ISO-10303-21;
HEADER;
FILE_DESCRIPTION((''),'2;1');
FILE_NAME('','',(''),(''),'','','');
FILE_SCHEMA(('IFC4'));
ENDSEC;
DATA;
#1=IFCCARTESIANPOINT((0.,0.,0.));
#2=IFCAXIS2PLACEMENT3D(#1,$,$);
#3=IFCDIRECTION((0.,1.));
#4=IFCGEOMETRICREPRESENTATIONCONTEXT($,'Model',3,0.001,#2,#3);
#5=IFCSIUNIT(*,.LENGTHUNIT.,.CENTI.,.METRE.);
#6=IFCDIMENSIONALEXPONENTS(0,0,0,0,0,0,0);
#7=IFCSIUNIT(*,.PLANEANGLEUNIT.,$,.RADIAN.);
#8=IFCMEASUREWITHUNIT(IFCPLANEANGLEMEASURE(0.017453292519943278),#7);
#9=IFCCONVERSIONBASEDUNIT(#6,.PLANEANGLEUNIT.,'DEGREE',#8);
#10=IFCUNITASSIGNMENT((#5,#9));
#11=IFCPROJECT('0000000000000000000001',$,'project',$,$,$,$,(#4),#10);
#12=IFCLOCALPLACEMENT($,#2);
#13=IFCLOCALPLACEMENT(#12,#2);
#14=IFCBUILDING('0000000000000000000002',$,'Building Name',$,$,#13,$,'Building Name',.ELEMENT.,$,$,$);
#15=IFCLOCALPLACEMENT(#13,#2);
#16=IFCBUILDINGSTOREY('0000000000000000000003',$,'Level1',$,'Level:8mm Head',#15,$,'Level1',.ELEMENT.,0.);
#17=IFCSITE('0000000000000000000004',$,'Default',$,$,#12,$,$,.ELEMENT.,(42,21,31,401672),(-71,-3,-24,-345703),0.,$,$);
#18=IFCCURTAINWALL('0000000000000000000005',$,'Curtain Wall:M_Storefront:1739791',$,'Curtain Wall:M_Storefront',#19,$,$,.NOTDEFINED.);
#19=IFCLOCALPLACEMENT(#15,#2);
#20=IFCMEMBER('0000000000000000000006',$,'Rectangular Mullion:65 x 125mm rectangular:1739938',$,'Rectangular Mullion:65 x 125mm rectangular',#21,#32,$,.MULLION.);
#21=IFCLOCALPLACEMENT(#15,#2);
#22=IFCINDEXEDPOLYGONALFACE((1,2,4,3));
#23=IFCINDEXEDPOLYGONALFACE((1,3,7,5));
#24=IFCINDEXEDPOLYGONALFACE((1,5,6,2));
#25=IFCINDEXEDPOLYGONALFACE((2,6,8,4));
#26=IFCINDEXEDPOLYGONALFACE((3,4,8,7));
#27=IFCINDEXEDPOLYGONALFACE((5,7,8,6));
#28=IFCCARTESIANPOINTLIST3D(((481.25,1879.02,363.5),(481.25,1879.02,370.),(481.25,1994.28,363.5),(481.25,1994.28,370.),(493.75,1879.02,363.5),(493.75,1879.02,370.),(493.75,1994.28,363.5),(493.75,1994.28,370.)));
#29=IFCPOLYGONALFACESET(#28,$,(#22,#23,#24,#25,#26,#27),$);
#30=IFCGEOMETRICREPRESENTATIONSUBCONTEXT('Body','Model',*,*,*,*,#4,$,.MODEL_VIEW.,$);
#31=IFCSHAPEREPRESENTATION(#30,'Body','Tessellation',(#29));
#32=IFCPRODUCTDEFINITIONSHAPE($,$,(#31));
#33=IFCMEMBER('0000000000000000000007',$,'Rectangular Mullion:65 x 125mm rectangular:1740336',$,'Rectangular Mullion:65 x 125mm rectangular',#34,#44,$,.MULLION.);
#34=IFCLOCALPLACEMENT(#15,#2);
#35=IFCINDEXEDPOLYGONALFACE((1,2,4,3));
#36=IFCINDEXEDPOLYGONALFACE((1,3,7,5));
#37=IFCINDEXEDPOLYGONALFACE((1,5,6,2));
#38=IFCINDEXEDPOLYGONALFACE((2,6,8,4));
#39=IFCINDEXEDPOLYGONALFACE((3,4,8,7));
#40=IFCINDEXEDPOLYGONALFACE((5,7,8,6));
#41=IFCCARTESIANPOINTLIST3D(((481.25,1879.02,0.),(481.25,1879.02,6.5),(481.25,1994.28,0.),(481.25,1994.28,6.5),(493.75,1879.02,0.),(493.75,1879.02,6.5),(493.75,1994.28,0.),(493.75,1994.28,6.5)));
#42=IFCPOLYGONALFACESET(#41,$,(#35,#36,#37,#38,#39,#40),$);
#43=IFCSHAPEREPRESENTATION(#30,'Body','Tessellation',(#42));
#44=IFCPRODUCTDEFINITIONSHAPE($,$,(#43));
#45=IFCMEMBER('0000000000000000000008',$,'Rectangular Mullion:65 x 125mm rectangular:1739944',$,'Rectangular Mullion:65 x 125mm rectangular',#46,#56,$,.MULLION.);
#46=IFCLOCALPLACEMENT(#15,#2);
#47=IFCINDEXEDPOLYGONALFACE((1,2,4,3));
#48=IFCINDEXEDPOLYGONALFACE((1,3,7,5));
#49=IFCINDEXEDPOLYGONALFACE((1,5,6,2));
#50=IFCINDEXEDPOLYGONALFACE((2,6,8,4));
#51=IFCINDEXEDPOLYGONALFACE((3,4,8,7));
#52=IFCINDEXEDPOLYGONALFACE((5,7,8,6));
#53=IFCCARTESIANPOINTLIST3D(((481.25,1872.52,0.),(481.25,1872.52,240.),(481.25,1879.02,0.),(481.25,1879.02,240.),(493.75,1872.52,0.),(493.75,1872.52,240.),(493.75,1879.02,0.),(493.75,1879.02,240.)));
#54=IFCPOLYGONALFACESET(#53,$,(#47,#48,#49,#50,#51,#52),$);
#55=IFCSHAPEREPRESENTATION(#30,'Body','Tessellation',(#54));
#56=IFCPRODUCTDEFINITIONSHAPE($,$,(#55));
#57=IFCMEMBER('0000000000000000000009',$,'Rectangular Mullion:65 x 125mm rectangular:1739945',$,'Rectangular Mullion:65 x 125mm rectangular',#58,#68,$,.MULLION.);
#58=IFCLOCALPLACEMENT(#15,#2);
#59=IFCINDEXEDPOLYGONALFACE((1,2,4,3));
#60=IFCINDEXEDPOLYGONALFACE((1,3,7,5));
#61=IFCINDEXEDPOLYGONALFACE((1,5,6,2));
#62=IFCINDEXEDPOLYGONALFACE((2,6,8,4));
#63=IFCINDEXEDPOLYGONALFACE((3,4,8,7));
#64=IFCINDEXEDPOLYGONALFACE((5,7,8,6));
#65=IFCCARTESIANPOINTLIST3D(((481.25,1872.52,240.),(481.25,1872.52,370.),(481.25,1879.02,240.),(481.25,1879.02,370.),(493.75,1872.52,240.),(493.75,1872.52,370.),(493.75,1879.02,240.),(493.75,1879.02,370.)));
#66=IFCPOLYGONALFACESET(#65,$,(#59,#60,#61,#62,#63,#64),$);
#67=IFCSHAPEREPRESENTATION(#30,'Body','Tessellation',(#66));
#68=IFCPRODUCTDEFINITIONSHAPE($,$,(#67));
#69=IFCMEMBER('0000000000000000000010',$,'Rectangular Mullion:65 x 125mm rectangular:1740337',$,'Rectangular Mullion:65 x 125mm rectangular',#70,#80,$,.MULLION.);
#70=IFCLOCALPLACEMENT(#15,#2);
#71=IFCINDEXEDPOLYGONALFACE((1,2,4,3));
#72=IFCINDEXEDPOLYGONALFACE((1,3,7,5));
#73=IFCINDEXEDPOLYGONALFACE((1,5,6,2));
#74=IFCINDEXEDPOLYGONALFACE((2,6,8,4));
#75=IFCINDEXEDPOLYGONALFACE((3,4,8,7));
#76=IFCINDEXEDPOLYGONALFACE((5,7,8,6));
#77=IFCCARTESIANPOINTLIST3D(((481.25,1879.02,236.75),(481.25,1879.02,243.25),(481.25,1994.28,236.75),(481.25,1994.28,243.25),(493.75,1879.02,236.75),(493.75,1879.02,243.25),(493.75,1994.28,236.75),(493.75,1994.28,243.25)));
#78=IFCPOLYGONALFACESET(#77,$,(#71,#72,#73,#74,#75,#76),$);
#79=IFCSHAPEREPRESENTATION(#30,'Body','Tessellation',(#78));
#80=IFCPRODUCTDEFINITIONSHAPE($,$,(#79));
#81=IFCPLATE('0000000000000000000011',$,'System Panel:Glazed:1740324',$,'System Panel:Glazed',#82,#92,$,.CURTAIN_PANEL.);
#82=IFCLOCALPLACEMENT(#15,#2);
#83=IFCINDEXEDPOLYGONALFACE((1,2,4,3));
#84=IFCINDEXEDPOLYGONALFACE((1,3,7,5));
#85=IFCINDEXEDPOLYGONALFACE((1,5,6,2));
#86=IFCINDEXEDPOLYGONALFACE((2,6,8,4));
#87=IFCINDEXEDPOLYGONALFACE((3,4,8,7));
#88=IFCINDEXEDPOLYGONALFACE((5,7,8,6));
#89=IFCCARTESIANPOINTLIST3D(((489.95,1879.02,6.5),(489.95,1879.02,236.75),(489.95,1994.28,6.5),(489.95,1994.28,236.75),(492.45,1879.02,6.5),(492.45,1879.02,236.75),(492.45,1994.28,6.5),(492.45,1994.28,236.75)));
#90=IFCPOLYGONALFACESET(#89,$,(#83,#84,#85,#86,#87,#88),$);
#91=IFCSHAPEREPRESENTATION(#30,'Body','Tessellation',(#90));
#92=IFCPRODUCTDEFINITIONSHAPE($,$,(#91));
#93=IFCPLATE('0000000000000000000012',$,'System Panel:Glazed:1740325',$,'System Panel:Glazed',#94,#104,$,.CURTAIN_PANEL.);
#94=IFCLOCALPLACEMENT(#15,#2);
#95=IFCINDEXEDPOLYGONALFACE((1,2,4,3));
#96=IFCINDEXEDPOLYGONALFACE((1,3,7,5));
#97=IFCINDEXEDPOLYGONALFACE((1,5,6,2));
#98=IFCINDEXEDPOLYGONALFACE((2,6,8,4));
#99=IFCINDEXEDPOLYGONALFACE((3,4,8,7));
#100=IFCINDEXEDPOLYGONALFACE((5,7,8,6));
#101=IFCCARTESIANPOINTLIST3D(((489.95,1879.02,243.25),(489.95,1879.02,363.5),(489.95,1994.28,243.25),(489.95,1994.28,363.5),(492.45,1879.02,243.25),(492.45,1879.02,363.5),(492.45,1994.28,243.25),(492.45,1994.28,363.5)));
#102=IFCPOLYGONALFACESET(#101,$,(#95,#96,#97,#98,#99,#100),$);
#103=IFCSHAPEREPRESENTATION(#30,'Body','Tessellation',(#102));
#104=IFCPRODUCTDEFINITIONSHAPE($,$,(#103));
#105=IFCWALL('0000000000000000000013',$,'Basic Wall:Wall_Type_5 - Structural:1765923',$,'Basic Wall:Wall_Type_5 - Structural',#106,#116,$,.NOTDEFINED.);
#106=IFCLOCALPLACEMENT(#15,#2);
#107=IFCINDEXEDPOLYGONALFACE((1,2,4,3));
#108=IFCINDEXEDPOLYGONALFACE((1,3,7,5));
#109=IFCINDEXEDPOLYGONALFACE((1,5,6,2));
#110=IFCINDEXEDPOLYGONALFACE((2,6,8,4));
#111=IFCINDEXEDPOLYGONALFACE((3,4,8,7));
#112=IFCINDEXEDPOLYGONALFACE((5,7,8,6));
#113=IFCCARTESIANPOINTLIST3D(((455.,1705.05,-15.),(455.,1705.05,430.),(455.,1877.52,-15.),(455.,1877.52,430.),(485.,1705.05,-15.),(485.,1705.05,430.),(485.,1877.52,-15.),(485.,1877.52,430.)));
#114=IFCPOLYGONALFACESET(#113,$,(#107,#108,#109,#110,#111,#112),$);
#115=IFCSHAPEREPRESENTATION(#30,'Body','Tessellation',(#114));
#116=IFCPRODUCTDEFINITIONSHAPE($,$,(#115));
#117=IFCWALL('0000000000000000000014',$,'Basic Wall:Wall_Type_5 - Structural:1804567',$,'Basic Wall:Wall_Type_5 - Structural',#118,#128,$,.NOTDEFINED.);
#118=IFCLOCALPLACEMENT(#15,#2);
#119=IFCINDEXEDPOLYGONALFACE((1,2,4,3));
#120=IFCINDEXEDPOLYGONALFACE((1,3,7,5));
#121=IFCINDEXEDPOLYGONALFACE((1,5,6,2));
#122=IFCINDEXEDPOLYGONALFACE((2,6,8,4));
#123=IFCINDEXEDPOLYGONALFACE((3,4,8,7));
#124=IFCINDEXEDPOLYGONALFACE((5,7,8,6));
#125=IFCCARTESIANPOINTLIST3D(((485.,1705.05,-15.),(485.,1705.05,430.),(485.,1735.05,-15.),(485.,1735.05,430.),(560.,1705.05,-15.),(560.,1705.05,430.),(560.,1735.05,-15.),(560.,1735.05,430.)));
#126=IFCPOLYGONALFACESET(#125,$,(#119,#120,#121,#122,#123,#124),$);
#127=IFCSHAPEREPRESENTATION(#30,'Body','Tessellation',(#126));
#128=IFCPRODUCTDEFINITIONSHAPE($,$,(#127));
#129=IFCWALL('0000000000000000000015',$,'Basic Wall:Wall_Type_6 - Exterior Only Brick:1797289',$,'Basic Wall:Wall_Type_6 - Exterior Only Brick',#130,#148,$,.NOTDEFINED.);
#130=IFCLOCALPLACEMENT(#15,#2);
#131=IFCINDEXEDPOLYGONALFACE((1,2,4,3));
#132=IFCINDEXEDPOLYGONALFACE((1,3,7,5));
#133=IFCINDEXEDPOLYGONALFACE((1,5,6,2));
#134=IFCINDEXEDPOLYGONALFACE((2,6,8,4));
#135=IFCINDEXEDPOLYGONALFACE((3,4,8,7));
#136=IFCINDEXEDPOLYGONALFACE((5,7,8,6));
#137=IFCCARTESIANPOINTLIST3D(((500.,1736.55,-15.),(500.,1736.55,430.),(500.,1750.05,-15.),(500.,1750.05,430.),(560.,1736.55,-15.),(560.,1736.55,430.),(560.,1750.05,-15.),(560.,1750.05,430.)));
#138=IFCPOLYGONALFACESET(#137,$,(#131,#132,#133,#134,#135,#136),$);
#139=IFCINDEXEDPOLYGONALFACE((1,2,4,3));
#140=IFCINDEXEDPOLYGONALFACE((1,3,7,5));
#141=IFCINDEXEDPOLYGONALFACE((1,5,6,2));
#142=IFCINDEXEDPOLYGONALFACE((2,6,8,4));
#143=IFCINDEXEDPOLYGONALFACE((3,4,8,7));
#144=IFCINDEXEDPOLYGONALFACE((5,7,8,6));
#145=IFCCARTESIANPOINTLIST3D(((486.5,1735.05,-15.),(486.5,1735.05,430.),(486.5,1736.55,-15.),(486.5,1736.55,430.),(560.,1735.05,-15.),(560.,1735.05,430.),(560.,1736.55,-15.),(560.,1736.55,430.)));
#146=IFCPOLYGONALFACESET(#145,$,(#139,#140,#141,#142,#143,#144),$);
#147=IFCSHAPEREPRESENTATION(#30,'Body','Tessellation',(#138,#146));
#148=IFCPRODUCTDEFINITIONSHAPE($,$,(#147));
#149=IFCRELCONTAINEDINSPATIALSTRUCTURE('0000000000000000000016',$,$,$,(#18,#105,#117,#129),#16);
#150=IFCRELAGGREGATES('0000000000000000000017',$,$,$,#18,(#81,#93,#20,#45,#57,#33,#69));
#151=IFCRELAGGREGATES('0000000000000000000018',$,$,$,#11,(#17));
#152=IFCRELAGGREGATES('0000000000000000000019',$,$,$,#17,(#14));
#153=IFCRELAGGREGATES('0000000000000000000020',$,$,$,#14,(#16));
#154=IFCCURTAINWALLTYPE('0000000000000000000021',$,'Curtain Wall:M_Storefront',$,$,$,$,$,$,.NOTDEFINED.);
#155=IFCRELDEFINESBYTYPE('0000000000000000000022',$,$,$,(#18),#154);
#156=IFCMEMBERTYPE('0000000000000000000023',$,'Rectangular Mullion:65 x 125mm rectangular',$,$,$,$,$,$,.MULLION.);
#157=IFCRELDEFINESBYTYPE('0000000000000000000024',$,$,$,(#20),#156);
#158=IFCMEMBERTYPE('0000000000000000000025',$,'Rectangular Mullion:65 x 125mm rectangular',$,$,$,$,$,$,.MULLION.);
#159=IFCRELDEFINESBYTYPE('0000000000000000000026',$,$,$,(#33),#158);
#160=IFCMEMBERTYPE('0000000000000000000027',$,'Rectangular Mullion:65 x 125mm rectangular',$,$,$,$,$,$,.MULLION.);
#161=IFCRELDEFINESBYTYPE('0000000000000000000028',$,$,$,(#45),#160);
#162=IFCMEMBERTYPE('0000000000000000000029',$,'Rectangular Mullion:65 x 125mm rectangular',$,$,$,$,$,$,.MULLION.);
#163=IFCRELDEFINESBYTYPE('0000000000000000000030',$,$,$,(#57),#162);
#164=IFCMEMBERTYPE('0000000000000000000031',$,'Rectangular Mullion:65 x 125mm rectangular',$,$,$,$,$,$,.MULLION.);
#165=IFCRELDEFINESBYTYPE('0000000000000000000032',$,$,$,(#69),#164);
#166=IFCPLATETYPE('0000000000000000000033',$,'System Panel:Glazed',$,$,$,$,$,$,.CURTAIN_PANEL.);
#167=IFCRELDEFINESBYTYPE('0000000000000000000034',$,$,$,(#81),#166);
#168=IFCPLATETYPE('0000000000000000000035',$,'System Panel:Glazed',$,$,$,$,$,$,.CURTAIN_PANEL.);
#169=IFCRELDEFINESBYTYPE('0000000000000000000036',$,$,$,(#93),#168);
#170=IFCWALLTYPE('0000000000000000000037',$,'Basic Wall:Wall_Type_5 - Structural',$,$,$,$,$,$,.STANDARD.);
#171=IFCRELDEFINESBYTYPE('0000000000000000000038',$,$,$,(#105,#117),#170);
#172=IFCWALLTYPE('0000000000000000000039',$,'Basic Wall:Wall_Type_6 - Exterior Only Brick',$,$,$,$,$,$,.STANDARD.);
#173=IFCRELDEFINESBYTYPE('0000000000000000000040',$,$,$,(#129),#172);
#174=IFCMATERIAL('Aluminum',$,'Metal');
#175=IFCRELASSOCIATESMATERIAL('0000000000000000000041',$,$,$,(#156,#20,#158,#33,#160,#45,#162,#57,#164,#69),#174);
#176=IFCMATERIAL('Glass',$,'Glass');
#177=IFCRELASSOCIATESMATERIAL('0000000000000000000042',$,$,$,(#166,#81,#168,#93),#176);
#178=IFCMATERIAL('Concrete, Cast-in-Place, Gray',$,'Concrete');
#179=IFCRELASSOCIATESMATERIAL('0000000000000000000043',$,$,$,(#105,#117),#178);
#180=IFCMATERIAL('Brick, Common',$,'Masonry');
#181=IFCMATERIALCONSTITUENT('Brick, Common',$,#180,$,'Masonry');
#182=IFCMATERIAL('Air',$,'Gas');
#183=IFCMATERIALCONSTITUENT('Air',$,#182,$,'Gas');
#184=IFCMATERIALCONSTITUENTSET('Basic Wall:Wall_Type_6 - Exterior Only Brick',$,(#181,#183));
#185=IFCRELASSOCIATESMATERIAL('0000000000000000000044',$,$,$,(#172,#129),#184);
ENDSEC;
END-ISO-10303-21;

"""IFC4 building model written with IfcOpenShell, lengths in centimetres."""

from ifc_helpers import new_model, entity, si_unit, converted_unit, direction, frame, origin, place, context, subcontext, project, spatial, indexed_curve, outline, extrude, source, transform, mapped, material, constituent, constituent_set, type_object, type_shapes, element, aggregate, save


model = new_model("IFC4")

# Units and contexts
model_context = context("Model", 3, precision=0.001, world=origin(), true_north=direction((0.0, 1.0)))
body_context = subcontext(model_context, "Body", "Model", "MODEL_VIEW")
ifc_project = project(units=[si_unit("LENGTHUNIT", "METRE", prefix="CENTI"), converted_unit("PLANEANGLEUNIT", "DEGREE", entity("IfcPlaneAngleMeasure", 0.017453292519943278), si_unit("PLANEANGLEUNIT", "RADIAN"), dimensions=[0, 0, 0, 0, 0, 0, 0])], contexts=[model_context])

# Site, building, storey
site_placement = place(None, origin())
site = spatial("IfcSite", under=ifc_project, at=site_placement, Name="Default", CompositionType="ELEMENT", RefLatitude=(42, 21, 31, 401672), RefLongitude=(-71, -3, -24, -345703), RefElevation=0.0)
building_placement = place(site_placement, origin())
building = spatial("IfcBuilding", under=site, at=building_placement, Name="Building Name", LongName="Building Name", CompositionType="ELEMENT")
storey_placement = place(building_placement, origin())
storey = spatial("IfcBuildingStorey", under=building, at=storey_placement, Name="Level1", ObjectType="Level:8mm Head", LongName="Level1", CompositionType="ELEMENT", Elevation=0.0)

# Curtain wall, members, plates
curtain_wall_type = type_object("IfcCurtainWallType", Name="Curtain Wall:M_Storefront", PredefinedType="NOTDEFINED")
curtain_wall_placement = place(storey_placement, origin())
curtain_wall = element("IfcCurtainWall", 1, at=curtain_wall_placement, inside=storey, type_object=curtain_wall_type, Name="Curtain Wall:M_Storefront:1739791", ObjectType="Curtain Wall:M_Storefront", PredefinedType="NOTDEFINED")
ifc_material_1 = material(Name="Aluminum", Category="Metal")
member_type_1 = type_object("IfcMemberType", Name="Rectangular Mullion:65 x 125mm rectangular", PredefinedType="MULLION", material=ifc_material_1)
shared_shape_1 = source(origin(), body_context, "Body", "SweptSolid", [
    extrude(outline(indexed_curve([(-3.25, -6.25), (3.25, -6.25), (3.25, 6.25), (-3.25, 6.25), (-3.25, -6.25)], self_intersect=False)), frame((-3.25, 0.0, -115.25), z_axis=(0.0, 0.0, 1.0), x_axis=(-1.0, 0.0, 0.0)), (0.0, 0.0, 1.0), 115.25),
])
type_shapes(member_type_1, [shared_shape_1])
member_1_placement = place(curtain_wall_placement, frame((487.5, 1879.02, 370.0), z_axis=(0.0, -1.0, 0.0), x_axis=(0.0, 0.0, 1.0)))
member_1 = element("IfcMember", 2, at=member_1_placement, type_object=member_type_1, material=ifc_material_1, Name="Rectangular Mullion:65 x 125mm rectangular:1739938", ObjectType="Rectangular Mullion:65 x 125mm rectangular", PredefinedType="MULLION", context=body_context, shape_type="MappedRepresentation", body=[
    mapped(shared_shape_1, transform((0.0, 0.0, 0.0), scale=1.0)),
])
member_type_2 = type_object("IfcMemberType", Name="Rectangular Mullion:65 x 125mm rectangular", PredefinedType="MULLION", material=ifc_material_1)
shared_shape_2 = source(origin(), body_context, "Body", "SweptSolid", [
    extrude(outline(indexed_curve([(-3.25, -6.25), (3.25, -6.25), (3.25, 6.25), (-3.25, 6.25), (-3.25, -6.25)], self_intersect=False)), frame((-3.25, 0.0, -115.25), z_axis=(0.0, 0.0, 1.0), x_axis=(-1.0, 0.0, 0.0)), (0.0, 0.0, 1.0), 115.25),
])
type_shapes(member_type_2, [shared_shape_2])
member_2_placement = place(curtain_wall_placement, frame((487.5, 1994.28, 0.0), z_axis=(0.0, 1.0, 0.0), x_axis=(0.0, 0.0, -1.0)))
member_2 = element("IfcMember", 3, at=member_2_placement, type_object=member_type_2, material=ifc_material_1, Name="Rectangular Mullion:65 x 125mm rectangular:1740336", ObjectType="Rectangular Mullion:65 x 125mm rectangular", PredefinedType="MULLION", context=body_context, shape_type="MappedRepresentation", body=[
    mapped(shared_shape_2, transform((0.0, 0.0, 0.0), scale=1.0)),
])
member_type_3 = type_object("IfcMemberType", Name="Rectangular Mullion:65 x 125mm rectangular", PredefinedType="MULLION", material=ifc_material_1)
shared_shape_3 = source(origin(), body_context, "Body", "SweptSolid", [
    extrude(outline(indexed_curve([(-3.25, -6.25), (3.25, -6.25), (3.25, 6.25), (-3.25, 6.25), (-3.25, -6.25)], self_intersect=False)), frame((-3.25, 0.0, -240.0), z_axis=(0.0, 0.0, 1.0), x_axis=(-1.0, 0.0, 0.0)), (0.0, 0.0, 1.0), 240.0),
])
type_shapes(member_type_3, [shared_shape_3])
member_3_placement = place(curtain_wall_placement, frame((487.5, 1872.52, 0.0), z_axis=(0.0, 0.0, -1.0), x_axis=(0.0, -1.0, 0.0)))
member_3 = element("IfcMember", 4, at=member_3_placement, type_object=member_type_3, material=ifc_material_1, Name="Rectangular Mullion:65 x 125mm rectangular:1739944", ObjectType="Rectangular Mullion:65 x 125mm rectangular", PredefinedType="MULLION", context=body_context, shape_type="MappedRepresentation", body=[
    mapped(shared_shape_3, transform((0.0, 0.0, 0.0), scale=1.0)),
])
member_type_4 = type_object("IfcMemberType", Name="Rectangular Mullion:65 x 125mm rectangular", PredefinedType="MULLION", material=ifc_material_1)
shared_shape_4 = source(origin(), body_context, "Body", "SweptSolid", [
    extrude(outline(indexed_curve([(-3.25, -6.25), (3.25, -6.25), (3.25, 6.25), (-3.25, 6.25), (-3.25, -6.25)], self_intersect=False)), frame((-3.25, 0.0, -130.0), z_axis=(0.0, 0.0, 1.0), x_axis=(-1.0, 0.0, 0.0)), (0.0, 0.0, 1.0), 130.0),
])
type_shapes(member_type_4, [shared_shape_4])
member_4_placement = place(curtain_wall_placement, frame((487.5, 1872.52, 240.0), z_axis=(0.0, 0.0, -1.0), x_axis=(0.0, -1.0, 0.0)))
member_4 = element("IfcMember", 5, at=member_4_placement, type_object=member_type_4, material=ifc_material_1, Name="Rectangular Mullion:65 x 125mm rectangular:1739945", ObjectType="Rectangular Mullion:65 x 125mm rectangular", PredefinedType="MULLION", context=body_context, shape_type="MappedRepresentation", body=[
    mapped(shared_shape_4, transform((0.0, 0.0, 0.0), scale=1.0)),
])
member_type_5 = type_object("IfcMemberType", Name="Rectangular Mullion:65 x 125mm rectangular", PredefinedType="MULLION", material=ifc_material_1)
shared_shape_5 = source(origin(), body_context, "Body", "SweptSolid", [
    extrude(outline(indexed_curve([(-3.25, -6.25), (3.25, -6.25), (3.25, 6.25), (-3.25, 6.25), (-3.25, -6.25)], self_intersect=False)), frame((0.0, 0.0, -115.25), z_axis=(0.0, 0.0, 1.0), x_axis=(-1.0, 0.0, 0.0)), (0.0, 0.0, 1.0), 115.25),
])
type_shapes(member_type_5, [shared_shape_5])
member_5_placement = place(curtain_wall_placement, frame((487.5, 1879.02, 240.0), z_axis=(0.0, -1.0, 0.0), x_axis=(0.0, 0.0, 1.0)))
member_5 = element("IfcMember", 6, at=member_5_placement, type_object=member_type_5, material=ifc_material_1, Name="Rectangular Mullion:65 x 125mm rectangular:1740337", ObjectType="Rectangular Mullion:65 x 125mm rectangular", PredefinedType="MULLION", context=body_context, shape_type="MappedRepresentation", body=[
    mapped(shared_shape_5, transform((0.0, 0.0, 0.0), scale=1.0)),
])
ifc_material_2 = material(Name="Glass", Category="Glass")
plate_type_1 = type_object("IfcPlateType", Name="System Panel:Glazed", PredefinedType="CURTAIN_PANEL", material=ifc_material_2)
shared_shape_6 = source(origin(), body_context, "Body", "SweptSolid", [
    extrude(outline(indexed_curve([(-1.25, -57.63), (1.25, -57.63), (1.25, 57.63), (-1.25, 57.63), (-1.25, -57.63)], self_intersect=False)), frame((0.0, 3.7, 0.0), z_axis=(0.0, 0.0, 1.0), x_axis=(0.0, 1.0, 0.0)), (0.0, 0.0, 1.0), 230.25),
])
type_shapes(plate_type_1, [shared_shape_6])
plate_1_placement = place(curtain_wall_placement, frame((487.5, 1936.65, 6.5), z_axis=(0.0, 0.0, 1.0), x_axis=(0.0, -1.0, 0.0)))
plate_1 = element("IfcPlate", 7, at=plate_1_placement, type_object=plate_type_1, material=ifc_material_2, Name="System Panel:Glazed:1740324", ObjectType="System Panel:Glazed", PredefinedType="CURTAIN_PANEL", context=body_context, shape_type="MappedRepresentation", body=[
    mapped(shared_shape_6, transform((0.0, 0.0, 0.0), scale=1.0)),
])
plate_type_2 = type_object("IfcPlateType", Name="System Panel:Glazed", PredefinedType="CURTAIN_PANEL", material=ifc_material_2)
shared_shape_7 = source(origin(), body_context, "Body", "SweptSolid", [
    extrude(outline(indexed_curve([(-1.25, -57.63), (1.25, -57.63), (1.25, 57.63), (-1.25, 57.63), (-1.25, -57.63)], self_intersect=False)), frame((0.0, 3.7, 0.0), z_axis=(0.0, 0.0, 1.0), x_axis=(0.0, 1.0, 0.0)), (0.0, 0.0, 1.0), 120.25),
])
type_shapes(plate_type_2, [shared_shape_7])
plate_2_placement = place(curtain_wall_placement, frame((487.5, 1936.65, 243.25), z_axis=(0.0, 0.0, 1.0), x_axis=(0.0, -1.0, 0.0)))
plate_2 = element("IfcPlate", 8, at=plate_2_placement, type_object=plate_type_2, material=ifc_material_2, Name="System Panel:Glazed:1740325", ObjectType="System Panel:Glazed", PredefinedType="CURTAIN_PANEL", context=body_context, shape_type="MappedRepresentation", body=[
    mapped(shared_shape_7, transform((0.0, 0.0, 0.0), scale=1.0)),
])
aggregate(curtain_wall, [plate_1, plate_2, member_1, member_3, member_4, member_2, member_5])

# Shared definitions
ifc_material_3 = material(Name="Brick, Common", Category="Masonry")
ifc_material_4 = material(Name="Air", Category="Gas")

# Walls
ifc_material_5 = material(Name="Concrete, Cast-in-Place, Gray", Category="Concrete")
wall_type_1 = type_object("IfcWallType", Name="Basic Wall:Wall_Type_5 - Structural", PredefinedType="STANDARD")
wall_1_placement = place(storey_placement, frame((470.0, 1877.52, -15.0), z_axis=(0.0, 0.0, 1.0), x_axis=(0.0, -1.0, 0.0)))
element("IfcWall", 9, at=wall_1_placement, inside=storey, type_object=wall_type_1, material=ifc_material_5, Name="Basic Wall:Wall_Type_5 - Structural:1765923", ObjectType="Basic Wall:Wall_Type_5 - Structural", PredefinedType="NOTDEFINED", context=body_context, shape_type="SweptSolid", body=[
    extrude(outline(indexed_curve([(172.47, 15.0), (0.0, 15.0), (0.0, -15.0), (172.47, -15.0), (172.47, 15.0)], self_intersect=False)), origin(), (0.0, 0.0, 1.0), 445.0),
])
wall_2_placement = place(storey_placement, frame((485.0, 1720.05, -15.0)))
element("IfcWall", 10, at=wall_2_placement, inside=storey, type_object=wall_type_1, material=ifc_material_5, Name="Basic Wall:Wall_Type_5 - Structural:1804567", ObjectType="Basic Wall:Wall_Type_5 - Structural", PredefinedType="NOTDEFINED", context=body_context, shape_type="SweptSolid", body=[
    extrude(outline(indexed_curve([(75.0, 15.0), (0.0, 15.0), (0.0, -15.0), (75.0, -15.0), (75.0, 15.0)], self_intersect=False)), origin(), (0.0, 0.0, 1.0), 445.0),
])

# Shared definitions
ifc_constituent_1 = constituent(ifc_material_3, Name="Brick, Common", Category="Masonry")
ifc_constituent_2 = constituent(ifc_material_4, Name="Air", Category="Gas")
ifc_constituent_set_1 = constituent_set(constituents=[ifc_constituent_1, ifc_constituent_2], Name="Basic Wall:Wall_Type_6 - Exterior Only Brick")
wall_type_2 = type_object("IfcWallType", Name="Basic Wall:Wall_Type_6 - Exterior Only Brick", PredefinedType="STANDARD", material=ifc_constituent_set_1)

# Wall
wall_3_placement = place(storey_placement, frame((500.0, 1742.55, -15.0)))
element("IfcWall", 11, at=wall_3_placement, inside=storey, type_object=wall_type_2, material=ifc_constituent_set_1, Name="Basic Wall:Wall_Type_6 - Exterior Only Brick:1797289", ObjectType="Basic Wall:Wall_Type_6 - Exterior Only Brick", PredefinedType="NOTDEFINED", context=body_context, shape_type="SweptSolid", body=[
    extrude(outline(indexed_curve([(-6.75, -30.0), (6.75, -30.0), (6.75, 30.0), (-6.75, 30.0), (-6.75, -30.0)], self_intersect=False)), frame((30.0, 0.75, 0.0), z_axis=(0.0, 0.0, 1.0), x_axis=(0.0, -1.0, 0.0)), (0.0, 0.0, 1.0), 445.0),
    extrude(outline(indexed_curve([(-0.75, -36.75), (0.75, -36.75), (0.75, 36.75), (-0.75, 36.75), (-0.75, -36.75)], self_intersect=False)), frame((23.25, -6.75, 0.0), z_axis=(0.0, 0.0, 1.0), x_axis=(0.0, 1.0, 0.0)), (0.0, 0.0, 1.0), 445.0),
])

save(model, "model.ifc")
